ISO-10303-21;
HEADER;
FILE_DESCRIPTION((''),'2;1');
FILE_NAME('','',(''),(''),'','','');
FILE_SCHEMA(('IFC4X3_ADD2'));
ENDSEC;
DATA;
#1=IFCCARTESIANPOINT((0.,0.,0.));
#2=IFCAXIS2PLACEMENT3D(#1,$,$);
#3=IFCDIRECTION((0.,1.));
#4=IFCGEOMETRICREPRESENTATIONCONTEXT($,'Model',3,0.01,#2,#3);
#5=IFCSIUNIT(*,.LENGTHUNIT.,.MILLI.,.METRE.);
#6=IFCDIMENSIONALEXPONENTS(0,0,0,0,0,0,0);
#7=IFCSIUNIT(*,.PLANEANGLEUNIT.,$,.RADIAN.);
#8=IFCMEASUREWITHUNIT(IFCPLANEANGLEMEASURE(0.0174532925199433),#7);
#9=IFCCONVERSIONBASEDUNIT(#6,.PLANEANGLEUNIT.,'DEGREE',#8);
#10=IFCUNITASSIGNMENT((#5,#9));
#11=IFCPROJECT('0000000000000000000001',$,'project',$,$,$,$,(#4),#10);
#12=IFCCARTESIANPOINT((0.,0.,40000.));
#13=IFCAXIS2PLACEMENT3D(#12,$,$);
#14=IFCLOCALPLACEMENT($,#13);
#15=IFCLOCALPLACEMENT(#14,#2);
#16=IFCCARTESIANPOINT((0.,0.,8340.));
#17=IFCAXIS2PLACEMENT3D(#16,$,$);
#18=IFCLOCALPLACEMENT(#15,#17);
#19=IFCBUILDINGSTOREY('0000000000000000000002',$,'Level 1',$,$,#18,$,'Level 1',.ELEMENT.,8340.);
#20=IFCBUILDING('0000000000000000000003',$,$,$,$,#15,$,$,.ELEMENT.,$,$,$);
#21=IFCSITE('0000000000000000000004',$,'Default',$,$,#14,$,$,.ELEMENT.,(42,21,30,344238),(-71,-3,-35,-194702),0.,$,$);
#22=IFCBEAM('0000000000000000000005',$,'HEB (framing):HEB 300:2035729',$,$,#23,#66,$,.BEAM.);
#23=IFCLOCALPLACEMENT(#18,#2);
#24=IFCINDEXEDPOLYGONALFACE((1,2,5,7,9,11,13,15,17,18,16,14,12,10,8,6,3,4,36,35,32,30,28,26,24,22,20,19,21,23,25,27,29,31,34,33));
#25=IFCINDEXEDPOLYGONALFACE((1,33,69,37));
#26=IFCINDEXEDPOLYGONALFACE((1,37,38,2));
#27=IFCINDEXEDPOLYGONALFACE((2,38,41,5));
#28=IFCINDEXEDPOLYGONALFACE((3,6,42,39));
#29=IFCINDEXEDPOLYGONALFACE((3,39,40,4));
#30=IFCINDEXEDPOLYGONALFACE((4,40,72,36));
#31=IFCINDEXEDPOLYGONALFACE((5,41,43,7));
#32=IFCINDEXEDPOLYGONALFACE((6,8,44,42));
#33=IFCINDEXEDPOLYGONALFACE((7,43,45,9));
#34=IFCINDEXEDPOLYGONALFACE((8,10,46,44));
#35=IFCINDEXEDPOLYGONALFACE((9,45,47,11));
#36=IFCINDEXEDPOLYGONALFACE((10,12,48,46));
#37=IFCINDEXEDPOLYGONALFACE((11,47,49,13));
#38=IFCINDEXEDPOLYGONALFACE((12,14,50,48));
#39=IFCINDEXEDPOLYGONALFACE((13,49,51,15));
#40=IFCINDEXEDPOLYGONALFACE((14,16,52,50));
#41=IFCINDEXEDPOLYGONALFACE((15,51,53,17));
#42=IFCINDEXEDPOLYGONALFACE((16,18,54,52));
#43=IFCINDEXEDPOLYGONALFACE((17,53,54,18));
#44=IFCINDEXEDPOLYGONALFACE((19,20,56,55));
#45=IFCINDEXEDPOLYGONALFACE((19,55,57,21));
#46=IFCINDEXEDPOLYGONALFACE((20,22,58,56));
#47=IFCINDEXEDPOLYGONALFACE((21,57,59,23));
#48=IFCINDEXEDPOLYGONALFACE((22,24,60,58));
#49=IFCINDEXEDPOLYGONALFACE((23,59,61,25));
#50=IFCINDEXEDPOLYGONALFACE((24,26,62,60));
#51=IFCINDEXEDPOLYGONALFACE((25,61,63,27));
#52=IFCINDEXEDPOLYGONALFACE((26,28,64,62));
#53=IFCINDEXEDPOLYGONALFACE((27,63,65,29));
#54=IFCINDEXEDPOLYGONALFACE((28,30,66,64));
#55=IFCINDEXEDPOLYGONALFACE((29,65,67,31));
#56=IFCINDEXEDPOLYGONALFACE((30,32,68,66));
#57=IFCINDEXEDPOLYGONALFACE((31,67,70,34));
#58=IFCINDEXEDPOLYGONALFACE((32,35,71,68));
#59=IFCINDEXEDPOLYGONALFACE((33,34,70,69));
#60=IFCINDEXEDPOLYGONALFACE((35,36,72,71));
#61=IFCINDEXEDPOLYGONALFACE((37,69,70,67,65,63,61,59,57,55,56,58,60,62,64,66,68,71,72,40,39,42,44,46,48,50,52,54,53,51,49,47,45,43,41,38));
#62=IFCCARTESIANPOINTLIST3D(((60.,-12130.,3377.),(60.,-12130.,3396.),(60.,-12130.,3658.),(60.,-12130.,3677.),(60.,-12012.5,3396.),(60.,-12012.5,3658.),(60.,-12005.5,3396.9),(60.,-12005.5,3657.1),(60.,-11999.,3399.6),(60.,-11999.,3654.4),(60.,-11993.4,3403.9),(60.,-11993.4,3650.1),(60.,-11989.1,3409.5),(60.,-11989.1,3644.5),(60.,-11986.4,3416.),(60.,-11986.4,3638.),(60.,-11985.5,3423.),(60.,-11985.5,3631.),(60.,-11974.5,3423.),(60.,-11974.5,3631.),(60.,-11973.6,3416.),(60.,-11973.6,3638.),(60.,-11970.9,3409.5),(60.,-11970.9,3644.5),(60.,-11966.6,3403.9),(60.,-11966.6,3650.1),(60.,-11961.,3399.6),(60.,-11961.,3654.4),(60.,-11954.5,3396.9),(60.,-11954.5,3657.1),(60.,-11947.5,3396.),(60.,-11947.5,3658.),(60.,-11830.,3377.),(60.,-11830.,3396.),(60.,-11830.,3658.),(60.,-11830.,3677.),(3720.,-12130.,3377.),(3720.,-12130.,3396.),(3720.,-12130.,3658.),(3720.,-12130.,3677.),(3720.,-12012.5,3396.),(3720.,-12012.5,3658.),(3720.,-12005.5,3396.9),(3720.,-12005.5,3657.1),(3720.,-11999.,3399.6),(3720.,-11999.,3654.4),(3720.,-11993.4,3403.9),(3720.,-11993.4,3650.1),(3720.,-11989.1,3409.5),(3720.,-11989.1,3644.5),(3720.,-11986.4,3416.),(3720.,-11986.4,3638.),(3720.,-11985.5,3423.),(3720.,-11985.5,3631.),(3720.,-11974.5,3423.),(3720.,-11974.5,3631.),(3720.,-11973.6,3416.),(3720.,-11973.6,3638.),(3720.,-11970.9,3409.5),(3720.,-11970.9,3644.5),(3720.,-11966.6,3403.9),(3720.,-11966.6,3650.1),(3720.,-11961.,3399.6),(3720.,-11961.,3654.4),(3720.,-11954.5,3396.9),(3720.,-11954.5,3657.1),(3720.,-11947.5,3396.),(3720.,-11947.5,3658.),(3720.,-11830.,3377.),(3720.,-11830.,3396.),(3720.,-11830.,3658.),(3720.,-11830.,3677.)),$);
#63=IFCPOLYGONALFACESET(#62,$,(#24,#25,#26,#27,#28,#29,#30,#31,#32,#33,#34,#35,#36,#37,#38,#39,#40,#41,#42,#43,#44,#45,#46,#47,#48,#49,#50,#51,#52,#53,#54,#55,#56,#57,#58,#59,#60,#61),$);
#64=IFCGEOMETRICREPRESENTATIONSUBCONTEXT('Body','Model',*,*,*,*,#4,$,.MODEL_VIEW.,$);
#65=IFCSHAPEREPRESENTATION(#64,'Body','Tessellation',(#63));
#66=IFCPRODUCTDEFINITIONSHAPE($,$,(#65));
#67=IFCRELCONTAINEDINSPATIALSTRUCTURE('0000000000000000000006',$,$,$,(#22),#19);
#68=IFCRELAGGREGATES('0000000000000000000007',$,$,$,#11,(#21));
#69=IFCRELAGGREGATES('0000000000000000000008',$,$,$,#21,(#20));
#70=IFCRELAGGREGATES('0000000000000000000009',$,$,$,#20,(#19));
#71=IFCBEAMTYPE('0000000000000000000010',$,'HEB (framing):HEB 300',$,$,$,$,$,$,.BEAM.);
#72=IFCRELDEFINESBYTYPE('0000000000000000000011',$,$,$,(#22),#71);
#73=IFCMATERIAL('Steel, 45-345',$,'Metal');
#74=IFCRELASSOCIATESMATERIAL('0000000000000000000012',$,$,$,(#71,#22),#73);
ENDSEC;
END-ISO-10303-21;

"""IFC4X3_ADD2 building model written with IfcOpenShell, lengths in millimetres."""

from ifc_helpers import new_model, entity, si_unit, converted_unit, direction, frame, frame_2d, origin, place, context, subcontext, project, spatial, polyline, circle_curve, parameter, trimmed, segment, composite_curve, outline, extrude, source, transform, mapped, material, material_profile, profile_set, profile_usage, type_object, type_shapes, element, save


model = new_model("IFC4X3_ADD2")

# Units and contexts
model_context = context("Model", 3, precision=0.01, world=origin(), true_north=direction((0.0, 1.0)))
body_context = subcontext(model_context, "Body", "Model", "MODEL_VIEW")
ifc_project = project(units=[si_unit("LENGTHUNIT", "METRE", prefix="MILLI"), converted_unit("PLANEANGLEUNIT", "DEGREE", entity("IfcPlaneAngleMeasure", 0.0174532925199433), si_unit("PLANEANGLEUNIT", "RADIAN"), dimensions=[0, 0, 0, 0, 0, 0, 0])], contexts=[model_context])

# Site, building, storey
site_placement = place(None, frame((0.0, 0.0, 40000.0)))
site = spatial("IfcSite", under=ifc_project, at=site_placement, Name="Default", CompositionType="ELEMENT", RefLatitude=(42, 21, 30, 344238), RefLongitude=(-71, -3, -35, -194702), RefElevation=0.0)
building_placement = place(site_placement, origin())
building = spatial("IfcBuilding", under=site, at=building_placement, CompositionType="ELEMENT")
storey_placement = place(building_placement, frame((0.0, 0.0, 8340.0)))
storey = spatial("IfcBuildingStorey", under=building, at=storey_placement, Name="Level 1", LongName="Level 1", CompositionType="ELEMENT", Elevation=8340.0)

# Shared definitions
ifc_material_1 = material(Name="Steel, 45-345", Category="Metal")

# Beam
ifc_material_profile_1 = material_profile(ifc_material_1, outline(composite_curve([segment(polyline([(-150.0, -131.0), (-150.0, -150.0)]), True, "CONTINUOUS"), segment(polyline([(-150.0, -150.0), (150.0, -150.0)]), True, "CONTINUOUS"), segment(polyline([(150.0, -150.0), (150.0, -131.0)]), True, "CONTINUOUS"), segment(polyline([(150.0, -131.0), (32.5, -131.0)]), True, "CONTINUOUS"), segment(trimmed(circle_curve(frame_2d((32.5, -104.0), x_axis=(1.0, 0.0)), 27.0), [parameter(180.0)], [parameter(270.0)], True, "PARAMETER"), False, "CONTINUOUS"), segment(polyline([(5.5, -104.0), (5.5, 104.0)]), True, "CONTINUOUS"), segment(trimmed(circle_curve(frame_2d((32.5, 104.0), x_axis=(1.0, 0.0)), 27.0), [parameter(90.0)], [parameter(180.0)], True, "PARAMETER"), False, "CONTINUOUS"), segment(polyline([(32.5, 131.0), (150.0, 131.0)]), True, "CONTINUOUS"), segment(polyline([(150.0, 131.0), (150.0, 150.0)]), True, "CONTINUOUS"), segment(polyline([(150.0, 150.0), (-150.0, 150.0)]), True, "CONTINUOUS"), segment(polyline([(-150.0, 150.0), (-150.0, 131.0)]), True, "CONTINUOUS"), segment(polyline([(-150.0, 131.0), (-32.5, 131.0)]), True, "CONTINUOUS"), segment(trimmed(circle_curve(frame_2d((-32.5, 104.0), x_axis=(1.0, 0.0)), 27.0), [parameter(360.0)], [parameter(90.0)], True, "PARAMETER"), False, "CONTINUOUS"), segment(polyline([(-5.5, 104.0), (-5.5, -104.0)]), True, "CONTINUOUS"), segment(trimmed(circle_curve(frame_2d((-32.5, -104.0), x_axis=(1.0, 0.0)), 27.0), [parameter(270.0)], [parameter(0.0)], True, "PARAMETER"), False, "CONTINUOUS"), segment(polyline([(-32.5, -131.0), (-150.0, -131.0)]), True, "CONTINUOUS")], self_intersect=False)), Name="HEB 300")
ifc_profile_set_1 = profile_set([ifc_material_profile_1], Name="HEB 300")
ifc_profile_usage_1 = profile_usage(ifc_profile_set_1, cardinal=8)
beam_type_1 = type_object("IfcBeamType", Name="HEB (framing):HEB 300", PredefinedType="BEAM", material=ifc_profile_set_1)
shared_shape_1 = source(origin(), body_context, "Body", "SweptSolid", [
    extrude(outline(composite_curve([segment(polyline([(-150.0, -131.0), (-150.0, -150.0)]), True, "CONTINUOUS"), segment(polyline([(-150.0, -150.0), (150.0, -150.0)]), True, "CONTINUOUS"), segment(polyline([(150.0, -150.0), (150.0, -131.0)]), True, "CONTINUOUS"), segment(polyline([(150.0, -131.0), (32.5, -131.0)]), True, "CONTINUOUS"), segment(trimmed(circle_curve(frame_2d((32.5, -104.0), x_axis=(1.0, 0.0)), 27.0), [parameter(180.0)], [parameter(270.0)], True, "PARAMETER"), False, "CONTINUOUS"), segment(polyline([(5.5, -104.0), (5.5, 104.0)]), True, "CONTINUOUS"), segment(trimmed(circle_curve(frame_2d((32.5, 104.0), x_axis=(1.0, 0.0)), 27.0), [parameter(90.0)], [parameter(180.0)], True, "PARAMETER"), False, "CONTINUOUS"), segment(polyline([(32.5, 131.0), (150.0, 131.0)]), True, "CONTINUOUS"), segment(polyline([(150.0, 131.0), (150.0, 150.0)]), True, "CONTINUOUS"), segment(polyline([(150.0, 150.0), (-150.0, 150.0)]), True, "CONTINUOUS"), segment(polyline([(-150.0, 150.0), (-150.0, 131.0)]), True, "CONTINUOUS"), segment(polyline([(-150.0, 131.0), (-32.5, 131.0)]), True, "CONTINUOUS"), segment(trimmed(circle_curve(frame_2d((-32.5, 104.0), x_axis=(1.0, 0.0)), 27.0), [parameter(360.0)], [parameter(90.0)], True, "PARAMETER"), False, "CONTINUOUS"), segment(polyline([(-5.5, 104.0), (-5.5, -104.0)]), True, "CONTINUOUS"), segment(trimmed(circle_curve(frame_2d((-32.5, -104.0), x_axis=(1.0, 0.0)), 27.0), [parameter(270.0)], [parameter(0.0)], True, "PARAMETER"), False, "CONTINUOUS"), segment(polyline([(-32.5, -131.0), (-150.0, -131.0)]), True, "CONTINUOUS")], self_intersect=False)), frame((-1785.0, 0.0, 0.0), z_axis=(-1.0, 0.0, 0.0), x_axis=(0.0, -1.0, 0.0)), (0.0, 0.0, -1.0), 3660.0),
])
type_shapes(beam_type_1, [shared_shape_1])
beam_placement = place(storey_placement, frame((1935.0, -11980.0, 3527.0), z_axis=(0.0, 0.0, 1.0), x_axis=(-1.0, 0.0, 0.0)))
element("IfcBeam", 1, at=beam_placement, inside=storey, type_object=beam_type_1, material=ifc_profile_usage_1, Name="HEB (framing):HEB 300:2035729", PredefinedType="BEAM", context=body_context, shape_type="MappedRepresentation", body=[
    mapped(shared_shape_1, transform((0.0, 0.0, 0.0), scale=1.0)),
])

save(model, "model.ifc")
